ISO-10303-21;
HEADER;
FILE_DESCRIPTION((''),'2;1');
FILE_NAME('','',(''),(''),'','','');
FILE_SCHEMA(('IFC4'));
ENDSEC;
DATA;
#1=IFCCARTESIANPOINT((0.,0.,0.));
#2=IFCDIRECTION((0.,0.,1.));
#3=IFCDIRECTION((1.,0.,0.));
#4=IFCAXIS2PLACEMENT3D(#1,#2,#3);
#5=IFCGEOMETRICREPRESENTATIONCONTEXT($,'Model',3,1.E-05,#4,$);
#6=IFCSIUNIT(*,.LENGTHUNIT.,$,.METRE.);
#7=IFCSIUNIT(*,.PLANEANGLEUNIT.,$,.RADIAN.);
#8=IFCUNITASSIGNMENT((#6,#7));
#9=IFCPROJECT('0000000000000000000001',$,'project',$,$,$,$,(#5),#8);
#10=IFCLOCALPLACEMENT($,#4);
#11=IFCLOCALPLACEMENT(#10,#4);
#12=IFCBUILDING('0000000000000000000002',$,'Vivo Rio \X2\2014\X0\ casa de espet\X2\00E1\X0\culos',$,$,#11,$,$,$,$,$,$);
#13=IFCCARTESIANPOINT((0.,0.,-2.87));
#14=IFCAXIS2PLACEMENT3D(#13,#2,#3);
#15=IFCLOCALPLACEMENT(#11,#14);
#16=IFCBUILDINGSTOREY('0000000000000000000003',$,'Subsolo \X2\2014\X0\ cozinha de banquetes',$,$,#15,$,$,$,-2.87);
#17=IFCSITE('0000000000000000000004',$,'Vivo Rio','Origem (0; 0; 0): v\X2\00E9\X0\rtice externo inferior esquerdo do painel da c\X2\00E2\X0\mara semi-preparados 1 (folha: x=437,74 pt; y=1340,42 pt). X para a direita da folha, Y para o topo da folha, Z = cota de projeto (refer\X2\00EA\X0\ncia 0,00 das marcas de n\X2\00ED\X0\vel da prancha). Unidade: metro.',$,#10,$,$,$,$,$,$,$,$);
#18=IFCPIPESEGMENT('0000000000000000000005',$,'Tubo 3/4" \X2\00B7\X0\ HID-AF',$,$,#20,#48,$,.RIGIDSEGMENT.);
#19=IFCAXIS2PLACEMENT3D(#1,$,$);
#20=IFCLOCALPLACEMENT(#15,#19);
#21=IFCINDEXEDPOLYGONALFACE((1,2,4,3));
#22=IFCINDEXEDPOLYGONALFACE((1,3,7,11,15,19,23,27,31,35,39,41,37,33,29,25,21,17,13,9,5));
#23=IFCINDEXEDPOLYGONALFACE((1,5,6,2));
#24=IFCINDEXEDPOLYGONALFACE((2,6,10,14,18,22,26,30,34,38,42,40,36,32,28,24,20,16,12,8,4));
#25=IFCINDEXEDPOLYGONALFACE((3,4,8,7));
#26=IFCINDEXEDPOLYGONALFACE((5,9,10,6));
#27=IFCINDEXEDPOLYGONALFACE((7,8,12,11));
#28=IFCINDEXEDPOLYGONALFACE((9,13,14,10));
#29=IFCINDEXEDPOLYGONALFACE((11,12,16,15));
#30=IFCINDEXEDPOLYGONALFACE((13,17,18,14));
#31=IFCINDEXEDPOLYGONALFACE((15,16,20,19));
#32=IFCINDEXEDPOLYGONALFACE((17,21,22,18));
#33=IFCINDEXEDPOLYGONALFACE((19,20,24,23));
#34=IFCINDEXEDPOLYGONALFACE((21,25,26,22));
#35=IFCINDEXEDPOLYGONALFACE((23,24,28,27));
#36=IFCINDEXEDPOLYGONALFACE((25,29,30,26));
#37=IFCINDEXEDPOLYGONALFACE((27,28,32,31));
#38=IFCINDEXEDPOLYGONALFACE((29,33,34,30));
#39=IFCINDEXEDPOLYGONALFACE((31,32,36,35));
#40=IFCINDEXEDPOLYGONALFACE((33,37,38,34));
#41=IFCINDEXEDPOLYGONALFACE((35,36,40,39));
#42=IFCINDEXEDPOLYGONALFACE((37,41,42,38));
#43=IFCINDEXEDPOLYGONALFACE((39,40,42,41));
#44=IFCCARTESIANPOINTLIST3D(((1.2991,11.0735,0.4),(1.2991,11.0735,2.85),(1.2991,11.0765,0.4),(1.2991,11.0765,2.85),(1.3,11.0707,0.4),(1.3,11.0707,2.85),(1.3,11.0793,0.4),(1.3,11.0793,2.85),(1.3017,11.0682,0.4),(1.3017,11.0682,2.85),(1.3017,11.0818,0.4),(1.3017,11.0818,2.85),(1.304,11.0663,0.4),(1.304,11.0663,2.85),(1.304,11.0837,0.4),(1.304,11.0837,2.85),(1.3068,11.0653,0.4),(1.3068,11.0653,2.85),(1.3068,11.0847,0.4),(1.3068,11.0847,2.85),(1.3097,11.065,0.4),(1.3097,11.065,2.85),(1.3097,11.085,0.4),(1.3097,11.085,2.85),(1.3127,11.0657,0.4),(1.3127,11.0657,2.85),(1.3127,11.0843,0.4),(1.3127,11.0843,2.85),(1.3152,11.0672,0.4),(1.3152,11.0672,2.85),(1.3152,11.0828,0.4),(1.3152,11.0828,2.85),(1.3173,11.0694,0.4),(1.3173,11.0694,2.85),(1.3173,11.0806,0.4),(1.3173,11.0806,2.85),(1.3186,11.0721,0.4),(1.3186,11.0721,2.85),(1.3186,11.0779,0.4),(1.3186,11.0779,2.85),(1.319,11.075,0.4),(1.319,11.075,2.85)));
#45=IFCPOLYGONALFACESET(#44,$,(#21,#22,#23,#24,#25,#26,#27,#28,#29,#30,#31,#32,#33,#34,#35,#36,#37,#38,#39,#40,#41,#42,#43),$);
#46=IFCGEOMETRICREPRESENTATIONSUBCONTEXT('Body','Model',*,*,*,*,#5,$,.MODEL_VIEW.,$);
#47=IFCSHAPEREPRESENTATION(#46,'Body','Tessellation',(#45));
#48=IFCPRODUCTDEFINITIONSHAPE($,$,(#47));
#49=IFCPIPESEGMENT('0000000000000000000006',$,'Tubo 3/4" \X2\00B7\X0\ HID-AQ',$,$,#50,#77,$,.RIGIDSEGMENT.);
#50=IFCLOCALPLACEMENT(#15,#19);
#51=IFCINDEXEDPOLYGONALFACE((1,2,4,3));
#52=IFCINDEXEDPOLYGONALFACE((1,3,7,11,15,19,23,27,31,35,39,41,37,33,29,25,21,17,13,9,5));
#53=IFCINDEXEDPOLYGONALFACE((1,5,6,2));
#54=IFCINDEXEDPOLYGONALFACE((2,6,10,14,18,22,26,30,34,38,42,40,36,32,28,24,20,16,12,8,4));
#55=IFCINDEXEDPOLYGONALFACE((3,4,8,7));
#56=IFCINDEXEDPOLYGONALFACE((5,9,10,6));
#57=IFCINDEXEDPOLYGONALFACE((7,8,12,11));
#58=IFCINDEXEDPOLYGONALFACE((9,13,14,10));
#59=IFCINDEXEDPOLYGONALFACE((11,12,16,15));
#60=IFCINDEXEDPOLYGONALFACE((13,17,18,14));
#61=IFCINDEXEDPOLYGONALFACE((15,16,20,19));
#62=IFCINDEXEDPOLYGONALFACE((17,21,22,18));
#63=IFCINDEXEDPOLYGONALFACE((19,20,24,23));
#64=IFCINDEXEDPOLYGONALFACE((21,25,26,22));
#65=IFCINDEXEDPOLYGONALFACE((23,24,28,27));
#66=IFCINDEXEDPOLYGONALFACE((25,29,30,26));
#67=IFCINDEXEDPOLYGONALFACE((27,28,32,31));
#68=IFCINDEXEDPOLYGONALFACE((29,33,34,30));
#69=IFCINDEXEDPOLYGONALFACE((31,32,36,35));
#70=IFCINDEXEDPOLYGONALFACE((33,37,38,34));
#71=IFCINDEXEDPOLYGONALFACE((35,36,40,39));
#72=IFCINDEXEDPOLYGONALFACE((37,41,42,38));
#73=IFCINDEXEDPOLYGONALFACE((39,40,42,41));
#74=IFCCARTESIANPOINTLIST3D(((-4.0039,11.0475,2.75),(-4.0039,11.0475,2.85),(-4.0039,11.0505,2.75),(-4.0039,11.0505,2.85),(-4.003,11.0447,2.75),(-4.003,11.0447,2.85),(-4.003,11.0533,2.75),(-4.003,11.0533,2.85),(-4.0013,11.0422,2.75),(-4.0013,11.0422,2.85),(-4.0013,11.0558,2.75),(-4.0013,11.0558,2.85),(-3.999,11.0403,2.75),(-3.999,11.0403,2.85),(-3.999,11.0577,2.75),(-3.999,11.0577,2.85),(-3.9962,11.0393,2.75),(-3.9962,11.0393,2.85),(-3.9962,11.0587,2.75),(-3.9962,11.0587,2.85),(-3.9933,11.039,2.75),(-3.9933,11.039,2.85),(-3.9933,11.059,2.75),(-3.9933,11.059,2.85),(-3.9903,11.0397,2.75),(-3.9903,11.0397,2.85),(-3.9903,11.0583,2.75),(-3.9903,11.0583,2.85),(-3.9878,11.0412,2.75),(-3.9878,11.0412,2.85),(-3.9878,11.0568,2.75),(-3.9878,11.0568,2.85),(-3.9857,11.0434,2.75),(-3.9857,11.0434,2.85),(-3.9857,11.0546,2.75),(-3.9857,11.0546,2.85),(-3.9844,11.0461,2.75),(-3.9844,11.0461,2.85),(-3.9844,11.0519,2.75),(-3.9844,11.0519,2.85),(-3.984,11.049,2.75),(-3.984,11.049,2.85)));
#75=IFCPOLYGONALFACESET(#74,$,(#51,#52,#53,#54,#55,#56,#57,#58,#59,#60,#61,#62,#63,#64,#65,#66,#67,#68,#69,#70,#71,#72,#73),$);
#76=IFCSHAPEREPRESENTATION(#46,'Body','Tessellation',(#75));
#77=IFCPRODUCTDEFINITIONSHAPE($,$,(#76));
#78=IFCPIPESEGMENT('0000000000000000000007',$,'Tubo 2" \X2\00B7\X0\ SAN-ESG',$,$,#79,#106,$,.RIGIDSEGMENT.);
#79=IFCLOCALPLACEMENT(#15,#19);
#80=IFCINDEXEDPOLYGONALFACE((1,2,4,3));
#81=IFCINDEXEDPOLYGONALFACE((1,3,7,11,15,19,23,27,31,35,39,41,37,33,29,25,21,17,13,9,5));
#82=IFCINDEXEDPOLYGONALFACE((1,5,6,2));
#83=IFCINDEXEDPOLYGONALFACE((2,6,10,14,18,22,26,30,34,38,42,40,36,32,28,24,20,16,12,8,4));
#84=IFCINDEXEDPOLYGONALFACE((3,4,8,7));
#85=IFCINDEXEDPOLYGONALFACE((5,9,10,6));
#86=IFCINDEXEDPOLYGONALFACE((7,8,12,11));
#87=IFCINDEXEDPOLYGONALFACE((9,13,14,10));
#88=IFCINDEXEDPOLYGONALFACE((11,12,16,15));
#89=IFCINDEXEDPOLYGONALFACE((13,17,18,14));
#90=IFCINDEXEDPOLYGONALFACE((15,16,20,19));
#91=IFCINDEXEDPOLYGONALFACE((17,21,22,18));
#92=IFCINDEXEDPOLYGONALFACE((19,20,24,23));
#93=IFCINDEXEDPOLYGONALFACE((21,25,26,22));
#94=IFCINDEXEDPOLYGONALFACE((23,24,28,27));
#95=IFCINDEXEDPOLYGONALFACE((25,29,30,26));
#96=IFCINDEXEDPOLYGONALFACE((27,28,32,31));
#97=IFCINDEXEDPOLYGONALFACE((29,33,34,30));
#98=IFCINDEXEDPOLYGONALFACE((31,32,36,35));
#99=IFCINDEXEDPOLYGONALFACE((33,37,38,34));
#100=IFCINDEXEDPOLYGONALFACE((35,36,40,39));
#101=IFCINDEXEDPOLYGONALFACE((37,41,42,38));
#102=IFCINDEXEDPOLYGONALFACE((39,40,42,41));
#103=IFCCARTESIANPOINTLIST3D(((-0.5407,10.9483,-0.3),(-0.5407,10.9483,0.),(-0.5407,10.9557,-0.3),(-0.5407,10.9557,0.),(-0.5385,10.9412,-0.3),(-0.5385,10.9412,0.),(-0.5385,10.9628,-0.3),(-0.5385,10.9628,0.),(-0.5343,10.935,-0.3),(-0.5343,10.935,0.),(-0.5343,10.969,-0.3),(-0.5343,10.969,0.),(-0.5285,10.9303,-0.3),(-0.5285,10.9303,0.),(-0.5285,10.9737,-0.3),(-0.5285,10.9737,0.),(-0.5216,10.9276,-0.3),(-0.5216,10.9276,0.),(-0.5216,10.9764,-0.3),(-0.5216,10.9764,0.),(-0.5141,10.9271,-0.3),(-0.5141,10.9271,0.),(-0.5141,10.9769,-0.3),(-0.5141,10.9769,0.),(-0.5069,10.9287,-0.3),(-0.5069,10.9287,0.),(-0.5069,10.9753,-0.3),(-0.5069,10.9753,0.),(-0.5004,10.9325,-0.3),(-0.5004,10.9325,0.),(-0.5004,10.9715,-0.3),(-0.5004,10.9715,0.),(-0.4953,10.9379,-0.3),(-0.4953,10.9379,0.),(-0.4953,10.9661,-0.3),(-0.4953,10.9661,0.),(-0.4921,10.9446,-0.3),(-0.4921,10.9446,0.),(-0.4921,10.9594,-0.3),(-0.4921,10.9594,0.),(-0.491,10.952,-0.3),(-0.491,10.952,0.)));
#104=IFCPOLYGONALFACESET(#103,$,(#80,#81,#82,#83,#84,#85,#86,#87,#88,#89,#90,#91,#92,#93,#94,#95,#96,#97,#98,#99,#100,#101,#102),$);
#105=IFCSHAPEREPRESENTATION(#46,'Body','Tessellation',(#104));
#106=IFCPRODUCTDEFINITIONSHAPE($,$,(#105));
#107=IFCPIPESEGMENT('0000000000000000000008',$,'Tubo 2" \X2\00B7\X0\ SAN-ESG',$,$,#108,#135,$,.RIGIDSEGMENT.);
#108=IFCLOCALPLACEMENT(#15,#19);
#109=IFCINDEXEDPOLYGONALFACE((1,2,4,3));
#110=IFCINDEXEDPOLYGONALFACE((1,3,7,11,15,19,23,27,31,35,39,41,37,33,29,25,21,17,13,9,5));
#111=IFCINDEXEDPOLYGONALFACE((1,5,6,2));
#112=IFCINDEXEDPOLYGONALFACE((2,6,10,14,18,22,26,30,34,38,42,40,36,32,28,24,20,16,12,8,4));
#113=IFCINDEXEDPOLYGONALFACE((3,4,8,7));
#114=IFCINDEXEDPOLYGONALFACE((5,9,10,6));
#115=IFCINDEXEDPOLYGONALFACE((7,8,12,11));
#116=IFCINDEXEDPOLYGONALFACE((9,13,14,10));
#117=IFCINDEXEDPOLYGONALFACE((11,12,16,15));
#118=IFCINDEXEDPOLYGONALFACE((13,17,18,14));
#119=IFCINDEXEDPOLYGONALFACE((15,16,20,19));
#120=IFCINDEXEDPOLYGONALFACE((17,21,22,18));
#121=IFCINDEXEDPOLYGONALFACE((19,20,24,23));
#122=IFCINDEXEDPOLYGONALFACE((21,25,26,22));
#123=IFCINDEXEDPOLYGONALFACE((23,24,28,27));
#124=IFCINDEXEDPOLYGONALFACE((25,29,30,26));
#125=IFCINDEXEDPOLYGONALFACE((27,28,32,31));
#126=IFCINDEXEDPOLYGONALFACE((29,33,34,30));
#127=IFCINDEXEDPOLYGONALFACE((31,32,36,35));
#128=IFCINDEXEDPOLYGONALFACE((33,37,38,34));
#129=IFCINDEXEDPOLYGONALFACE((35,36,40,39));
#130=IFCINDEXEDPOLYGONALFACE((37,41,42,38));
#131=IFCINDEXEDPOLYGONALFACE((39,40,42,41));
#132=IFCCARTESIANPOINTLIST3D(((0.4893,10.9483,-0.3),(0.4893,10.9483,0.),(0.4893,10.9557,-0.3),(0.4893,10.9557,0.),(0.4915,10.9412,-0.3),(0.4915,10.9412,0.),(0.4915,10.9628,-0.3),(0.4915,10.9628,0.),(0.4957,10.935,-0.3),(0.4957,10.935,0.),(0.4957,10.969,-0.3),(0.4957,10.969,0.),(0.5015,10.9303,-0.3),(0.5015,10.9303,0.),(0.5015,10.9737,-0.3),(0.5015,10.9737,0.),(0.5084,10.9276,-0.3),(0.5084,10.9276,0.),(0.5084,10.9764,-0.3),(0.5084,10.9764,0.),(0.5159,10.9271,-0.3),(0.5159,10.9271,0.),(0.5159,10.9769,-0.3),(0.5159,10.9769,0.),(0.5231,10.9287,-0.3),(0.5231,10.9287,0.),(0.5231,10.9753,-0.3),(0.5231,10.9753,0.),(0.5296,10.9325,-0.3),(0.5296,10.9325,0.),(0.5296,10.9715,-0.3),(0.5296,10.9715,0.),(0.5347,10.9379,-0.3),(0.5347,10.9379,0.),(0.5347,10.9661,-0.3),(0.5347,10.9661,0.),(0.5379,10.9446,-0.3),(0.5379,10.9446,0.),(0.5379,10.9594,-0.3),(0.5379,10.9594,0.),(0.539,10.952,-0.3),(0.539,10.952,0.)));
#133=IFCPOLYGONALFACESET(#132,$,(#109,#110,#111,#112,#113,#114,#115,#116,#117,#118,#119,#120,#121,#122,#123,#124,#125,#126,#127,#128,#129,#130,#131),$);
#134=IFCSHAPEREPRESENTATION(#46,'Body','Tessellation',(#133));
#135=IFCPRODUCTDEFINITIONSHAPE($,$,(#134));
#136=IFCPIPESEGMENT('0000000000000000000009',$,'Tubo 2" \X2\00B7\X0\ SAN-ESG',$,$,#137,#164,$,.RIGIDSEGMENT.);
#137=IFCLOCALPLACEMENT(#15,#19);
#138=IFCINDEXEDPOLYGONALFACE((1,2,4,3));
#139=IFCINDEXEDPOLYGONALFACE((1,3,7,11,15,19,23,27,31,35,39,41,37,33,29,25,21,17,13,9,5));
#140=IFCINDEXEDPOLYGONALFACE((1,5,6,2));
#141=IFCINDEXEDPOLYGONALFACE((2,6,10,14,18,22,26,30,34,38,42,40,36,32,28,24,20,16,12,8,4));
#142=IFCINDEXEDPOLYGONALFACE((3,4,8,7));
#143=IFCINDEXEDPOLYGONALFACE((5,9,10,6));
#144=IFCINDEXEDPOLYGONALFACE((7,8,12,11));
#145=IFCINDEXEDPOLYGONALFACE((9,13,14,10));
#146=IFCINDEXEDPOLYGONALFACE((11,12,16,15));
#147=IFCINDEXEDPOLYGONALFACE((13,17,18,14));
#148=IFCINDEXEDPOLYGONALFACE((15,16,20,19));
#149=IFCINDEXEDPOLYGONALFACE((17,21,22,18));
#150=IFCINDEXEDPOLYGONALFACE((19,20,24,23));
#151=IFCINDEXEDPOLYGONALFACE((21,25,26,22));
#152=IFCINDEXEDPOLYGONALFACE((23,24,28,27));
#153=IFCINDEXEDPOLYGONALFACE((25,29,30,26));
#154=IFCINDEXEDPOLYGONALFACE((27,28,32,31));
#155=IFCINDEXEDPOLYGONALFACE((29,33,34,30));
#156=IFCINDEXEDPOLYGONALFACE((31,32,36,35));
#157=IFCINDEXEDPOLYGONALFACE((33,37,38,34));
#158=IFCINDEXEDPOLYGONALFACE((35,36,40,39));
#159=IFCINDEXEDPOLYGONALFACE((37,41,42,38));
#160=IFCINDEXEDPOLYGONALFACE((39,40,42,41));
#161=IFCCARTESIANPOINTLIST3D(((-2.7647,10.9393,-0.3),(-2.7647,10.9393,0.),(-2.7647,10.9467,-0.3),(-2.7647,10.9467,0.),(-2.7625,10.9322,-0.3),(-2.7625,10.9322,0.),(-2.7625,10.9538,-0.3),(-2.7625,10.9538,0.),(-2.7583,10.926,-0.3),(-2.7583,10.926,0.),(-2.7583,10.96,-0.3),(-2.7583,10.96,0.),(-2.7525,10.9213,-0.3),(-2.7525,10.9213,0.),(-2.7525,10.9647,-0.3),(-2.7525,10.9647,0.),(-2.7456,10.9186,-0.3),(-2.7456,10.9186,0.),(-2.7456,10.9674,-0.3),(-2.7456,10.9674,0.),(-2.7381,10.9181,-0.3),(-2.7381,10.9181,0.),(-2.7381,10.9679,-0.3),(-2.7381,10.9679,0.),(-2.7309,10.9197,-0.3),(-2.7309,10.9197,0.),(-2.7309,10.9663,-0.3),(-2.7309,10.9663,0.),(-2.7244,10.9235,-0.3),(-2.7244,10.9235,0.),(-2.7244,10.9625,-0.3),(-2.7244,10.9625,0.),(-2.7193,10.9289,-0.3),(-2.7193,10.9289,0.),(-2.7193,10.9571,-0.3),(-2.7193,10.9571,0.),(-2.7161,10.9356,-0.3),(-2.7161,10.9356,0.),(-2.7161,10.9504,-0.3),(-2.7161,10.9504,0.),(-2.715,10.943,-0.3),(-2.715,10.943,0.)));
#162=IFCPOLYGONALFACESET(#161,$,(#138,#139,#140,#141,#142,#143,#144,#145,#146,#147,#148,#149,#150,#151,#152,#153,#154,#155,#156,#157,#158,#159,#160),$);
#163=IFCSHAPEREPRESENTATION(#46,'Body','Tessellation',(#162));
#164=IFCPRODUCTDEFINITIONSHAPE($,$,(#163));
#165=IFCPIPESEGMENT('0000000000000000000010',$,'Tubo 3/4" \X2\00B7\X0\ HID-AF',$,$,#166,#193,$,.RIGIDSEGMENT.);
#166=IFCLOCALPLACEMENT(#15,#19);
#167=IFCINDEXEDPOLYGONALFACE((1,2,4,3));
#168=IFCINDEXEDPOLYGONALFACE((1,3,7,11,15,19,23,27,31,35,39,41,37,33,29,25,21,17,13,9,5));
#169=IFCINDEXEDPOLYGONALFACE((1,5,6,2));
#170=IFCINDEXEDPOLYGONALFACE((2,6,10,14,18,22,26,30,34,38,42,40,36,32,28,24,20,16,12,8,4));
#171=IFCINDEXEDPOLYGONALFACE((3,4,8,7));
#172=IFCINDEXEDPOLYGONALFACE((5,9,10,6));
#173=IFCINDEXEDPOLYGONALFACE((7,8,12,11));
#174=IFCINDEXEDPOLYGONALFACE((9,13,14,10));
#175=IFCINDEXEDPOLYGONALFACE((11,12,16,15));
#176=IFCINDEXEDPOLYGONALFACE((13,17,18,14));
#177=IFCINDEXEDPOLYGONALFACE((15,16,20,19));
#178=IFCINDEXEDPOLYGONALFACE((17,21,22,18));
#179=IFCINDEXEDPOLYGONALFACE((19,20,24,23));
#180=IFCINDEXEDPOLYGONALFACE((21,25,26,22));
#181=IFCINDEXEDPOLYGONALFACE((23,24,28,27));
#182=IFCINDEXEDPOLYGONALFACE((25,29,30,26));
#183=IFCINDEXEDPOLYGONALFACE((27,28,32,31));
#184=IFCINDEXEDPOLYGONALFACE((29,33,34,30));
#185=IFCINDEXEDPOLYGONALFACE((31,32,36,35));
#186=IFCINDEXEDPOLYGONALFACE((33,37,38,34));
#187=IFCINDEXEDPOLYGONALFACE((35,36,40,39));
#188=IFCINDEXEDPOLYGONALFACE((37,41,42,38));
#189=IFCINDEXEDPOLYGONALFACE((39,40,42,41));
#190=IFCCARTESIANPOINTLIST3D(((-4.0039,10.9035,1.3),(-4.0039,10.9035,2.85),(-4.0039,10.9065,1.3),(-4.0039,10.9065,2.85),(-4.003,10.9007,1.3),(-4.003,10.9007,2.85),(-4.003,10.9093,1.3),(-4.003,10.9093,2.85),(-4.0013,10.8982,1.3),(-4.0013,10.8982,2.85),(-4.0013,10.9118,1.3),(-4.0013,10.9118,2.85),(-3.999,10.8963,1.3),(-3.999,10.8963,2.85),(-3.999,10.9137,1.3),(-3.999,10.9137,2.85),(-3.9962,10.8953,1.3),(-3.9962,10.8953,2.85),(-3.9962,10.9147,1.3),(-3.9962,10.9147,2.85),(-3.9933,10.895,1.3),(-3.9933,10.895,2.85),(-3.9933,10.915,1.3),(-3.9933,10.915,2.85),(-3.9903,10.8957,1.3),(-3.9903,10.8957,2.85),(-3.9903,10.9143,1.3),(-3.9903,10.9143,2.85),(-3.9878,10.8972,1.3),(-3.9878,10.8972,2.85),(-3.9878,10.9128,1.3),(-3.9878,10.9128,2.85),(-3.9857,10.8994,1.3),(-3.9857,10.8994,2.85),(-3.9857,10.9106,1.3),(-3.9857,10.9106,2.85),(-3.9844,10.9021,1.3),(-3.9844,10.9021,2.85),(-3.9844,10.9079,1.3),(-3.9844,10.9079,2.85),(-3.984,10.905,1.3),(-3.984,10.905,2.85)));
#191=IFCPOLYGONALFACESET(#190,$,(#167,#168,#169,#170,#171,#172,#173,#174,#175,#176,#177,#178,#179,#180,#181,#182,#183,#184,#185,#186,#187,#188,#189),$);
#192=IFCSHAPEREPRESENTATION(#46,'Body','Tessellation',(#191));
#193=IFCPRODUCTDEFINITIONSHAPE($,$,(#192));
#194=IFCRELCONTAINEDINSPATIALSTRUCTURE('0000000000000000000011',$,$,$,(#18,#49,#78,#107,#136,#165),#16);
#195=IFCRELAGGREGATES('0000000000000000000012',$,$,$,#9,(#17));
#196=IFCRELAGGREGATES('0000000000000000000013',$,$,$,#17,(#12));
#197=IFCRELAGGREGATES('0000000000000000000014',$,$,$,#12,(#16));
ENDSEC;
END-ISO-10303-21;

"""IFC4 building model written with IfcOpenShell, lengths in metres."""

from ifc_helpers import new_model, si_unit, frame, origin_with_axes, origin_2d, place, context, subcontext, project, spatial, circle, extrude, element, save


model = new_model("IFC4")

# Units and contexts
model_context = context("Model", 3, precision=1e-05, world=origin_with_axes())
body_context = subcontext(model_context, "Body", "Model", "MODEL_VIEW")
ifc_project = project(units=[si_unit("LENGTHUNIT", "METRE"), si_unit("PLANEANGLEUNIT", "RADIAN")], contexts=[model_context])

# Site, building, storey
site_placement = place(None, origin_with_axes())
site = spatial("IfcSite", under=ifc_project, at=site_placement, Name="Vivo Rio", Description="Origem (0; 0; 0): vértice externo inferior esquerdo do painel da câmara semi-preparados 1 (folha: x=437,74 pt; y=1340,42 pt). X para a direita da folha, Y para o topo da folha, Z = cota de projeto (referência 0,00 das marcas de nível da prancha). Unidade: metro.")
building_placement = place(site_placement, origin_with_axes())
building = spatial("IfcBuilding", under=site, at=building_placement, Name="Vivo Rio — casa de espetáculos")
storey_placement = place(building_placement, frame((0.0, 0.0, -2.87), z_axis=(0.0, 0.0, 1.0), x_axis=(1.0, 0.0, 0.0)))
storey = spatial("IfcBuildingStorey", under=building, at=storey_placement, Name="Subsolo — cozinha de banquetes", Elevation=-2.87)

# Pipe segments
pipe_segment_1_placement = place(storey_placement, origin_with_axes())
element("IfcPipeSegment", 1, at=pipe_segment_1_placement, inside=storey, Name="Tubo 3/4\" · HID-AF", PredefinedType="RIGIDSEGMENT", context=body_context, shape_type="SweptSolid", body=[
    extrude(circle(Radius=0.01, at=origin_2d()), frame((1.309, 11.075, 2.85), z_axis=(0.0, 0.0, -1.0), x_axis=(1.0, 0.0, 0.0)), (0.0, 0.0, 1.0), 2.45),
])
pipe_segment_2_placement = place(storey_placement, origin_with_axes())
element("IfcPipeSegment", 2, at=pipe_segment_2_placement, inside=storey, Name="Tubo 3/4\" · HID-AQ", PredefinedType="RIGIDSEGMENT", context=body_context, shape_type="SweptSolid", body=[
    extrude(circle(Radius=0.01, at=origin_2d()), frame((-3.994, 11.049, 2.85), z_axis=(0.0, 0.0, -1.0), x_axis=(1.0, 0.0, 0.0)), (0.0, 0.0, 1.0), 0.1),
])
pipe_segment_3_placement = place(storey_placement, origin_with_axes())
element("IfcPipeSegment", 3, at=pipe_segment_3_placement, inside=storey, Name="Tubo 2\" · SAN-ESG", PredefinedType="RIGIDSEGMENT", context=body_context, shape_type="SweptSolid", body=[
    extrude(circle(Radius=0.025, at=origin_2d()), frame((-0.516, 10.952, 0.0), z_axis=(0.0, 0.0, -1.0), x_axis=(1.0, 0.0, 0.0)), (0.0, 0.0, 1.0), 0.3),
])
pipe_segment_4_placement = place(storey_placement, origin_with_axes())
element("IfcPipeSegment", 4, at=pipe_segment_4_placement, inside=storey, Name="Tubo 2\" · SAN-ESG", PredefinedType="RIGIDSEGMENT", context=body_context, shape_type="SweptSolid", body=[
    extrude(circle(Radius=0.025, at=origin_2d()), frame((0.514, 10.952, 0.0), z_axis=(0.0, 0.0, -1.0), x_axis=(1.0, 0.0, 0.0)), (0.0, 0.0, 1.0), 0.3),
])
pipe_segment_5_placement = place(storey_placement, origin_with_axes())
element("IfcPipeSegment", 5, at=pipe_segment_5_placement, inside=storey, Name="Tubo 2\" · SAN-ESG", PredefinedType="RIGIDSEGMENT", context=body_context, shape_type="SweptSolid", body=[
    extrude(circle(Radius=0.025, at=origin_2d()), frame((-2.74, 10.943, 0.0), z_axis=(0.0, 0.0, -1.0), x_axis=(1.0, 0.0, 0.0)), (0.0, 0.0, 1.0), 0.3),
])
pipe_segment_6_placement = place(storey_placement, origin_with_axes())
element("IfcPipeSegment", 6, at=pipe_segment_6_placement, inside=storey, Name="Tubo 3/4\" · HID-AF", PredefinedType="RIGIDSEGMENT", context=body_context, shape_type="SweptSolid", body=[
    extrude(circle(Radius=0.01, at=origin_2d()), frame((-3.994, 10.905, 2.85), z_axis=(0.0, 0.0, -1.0), x_axis=(1.0, 0.0, 0.0)), (0.0, 0.0, 1.0), 1.55),
])

save(model, "model.ifc")
